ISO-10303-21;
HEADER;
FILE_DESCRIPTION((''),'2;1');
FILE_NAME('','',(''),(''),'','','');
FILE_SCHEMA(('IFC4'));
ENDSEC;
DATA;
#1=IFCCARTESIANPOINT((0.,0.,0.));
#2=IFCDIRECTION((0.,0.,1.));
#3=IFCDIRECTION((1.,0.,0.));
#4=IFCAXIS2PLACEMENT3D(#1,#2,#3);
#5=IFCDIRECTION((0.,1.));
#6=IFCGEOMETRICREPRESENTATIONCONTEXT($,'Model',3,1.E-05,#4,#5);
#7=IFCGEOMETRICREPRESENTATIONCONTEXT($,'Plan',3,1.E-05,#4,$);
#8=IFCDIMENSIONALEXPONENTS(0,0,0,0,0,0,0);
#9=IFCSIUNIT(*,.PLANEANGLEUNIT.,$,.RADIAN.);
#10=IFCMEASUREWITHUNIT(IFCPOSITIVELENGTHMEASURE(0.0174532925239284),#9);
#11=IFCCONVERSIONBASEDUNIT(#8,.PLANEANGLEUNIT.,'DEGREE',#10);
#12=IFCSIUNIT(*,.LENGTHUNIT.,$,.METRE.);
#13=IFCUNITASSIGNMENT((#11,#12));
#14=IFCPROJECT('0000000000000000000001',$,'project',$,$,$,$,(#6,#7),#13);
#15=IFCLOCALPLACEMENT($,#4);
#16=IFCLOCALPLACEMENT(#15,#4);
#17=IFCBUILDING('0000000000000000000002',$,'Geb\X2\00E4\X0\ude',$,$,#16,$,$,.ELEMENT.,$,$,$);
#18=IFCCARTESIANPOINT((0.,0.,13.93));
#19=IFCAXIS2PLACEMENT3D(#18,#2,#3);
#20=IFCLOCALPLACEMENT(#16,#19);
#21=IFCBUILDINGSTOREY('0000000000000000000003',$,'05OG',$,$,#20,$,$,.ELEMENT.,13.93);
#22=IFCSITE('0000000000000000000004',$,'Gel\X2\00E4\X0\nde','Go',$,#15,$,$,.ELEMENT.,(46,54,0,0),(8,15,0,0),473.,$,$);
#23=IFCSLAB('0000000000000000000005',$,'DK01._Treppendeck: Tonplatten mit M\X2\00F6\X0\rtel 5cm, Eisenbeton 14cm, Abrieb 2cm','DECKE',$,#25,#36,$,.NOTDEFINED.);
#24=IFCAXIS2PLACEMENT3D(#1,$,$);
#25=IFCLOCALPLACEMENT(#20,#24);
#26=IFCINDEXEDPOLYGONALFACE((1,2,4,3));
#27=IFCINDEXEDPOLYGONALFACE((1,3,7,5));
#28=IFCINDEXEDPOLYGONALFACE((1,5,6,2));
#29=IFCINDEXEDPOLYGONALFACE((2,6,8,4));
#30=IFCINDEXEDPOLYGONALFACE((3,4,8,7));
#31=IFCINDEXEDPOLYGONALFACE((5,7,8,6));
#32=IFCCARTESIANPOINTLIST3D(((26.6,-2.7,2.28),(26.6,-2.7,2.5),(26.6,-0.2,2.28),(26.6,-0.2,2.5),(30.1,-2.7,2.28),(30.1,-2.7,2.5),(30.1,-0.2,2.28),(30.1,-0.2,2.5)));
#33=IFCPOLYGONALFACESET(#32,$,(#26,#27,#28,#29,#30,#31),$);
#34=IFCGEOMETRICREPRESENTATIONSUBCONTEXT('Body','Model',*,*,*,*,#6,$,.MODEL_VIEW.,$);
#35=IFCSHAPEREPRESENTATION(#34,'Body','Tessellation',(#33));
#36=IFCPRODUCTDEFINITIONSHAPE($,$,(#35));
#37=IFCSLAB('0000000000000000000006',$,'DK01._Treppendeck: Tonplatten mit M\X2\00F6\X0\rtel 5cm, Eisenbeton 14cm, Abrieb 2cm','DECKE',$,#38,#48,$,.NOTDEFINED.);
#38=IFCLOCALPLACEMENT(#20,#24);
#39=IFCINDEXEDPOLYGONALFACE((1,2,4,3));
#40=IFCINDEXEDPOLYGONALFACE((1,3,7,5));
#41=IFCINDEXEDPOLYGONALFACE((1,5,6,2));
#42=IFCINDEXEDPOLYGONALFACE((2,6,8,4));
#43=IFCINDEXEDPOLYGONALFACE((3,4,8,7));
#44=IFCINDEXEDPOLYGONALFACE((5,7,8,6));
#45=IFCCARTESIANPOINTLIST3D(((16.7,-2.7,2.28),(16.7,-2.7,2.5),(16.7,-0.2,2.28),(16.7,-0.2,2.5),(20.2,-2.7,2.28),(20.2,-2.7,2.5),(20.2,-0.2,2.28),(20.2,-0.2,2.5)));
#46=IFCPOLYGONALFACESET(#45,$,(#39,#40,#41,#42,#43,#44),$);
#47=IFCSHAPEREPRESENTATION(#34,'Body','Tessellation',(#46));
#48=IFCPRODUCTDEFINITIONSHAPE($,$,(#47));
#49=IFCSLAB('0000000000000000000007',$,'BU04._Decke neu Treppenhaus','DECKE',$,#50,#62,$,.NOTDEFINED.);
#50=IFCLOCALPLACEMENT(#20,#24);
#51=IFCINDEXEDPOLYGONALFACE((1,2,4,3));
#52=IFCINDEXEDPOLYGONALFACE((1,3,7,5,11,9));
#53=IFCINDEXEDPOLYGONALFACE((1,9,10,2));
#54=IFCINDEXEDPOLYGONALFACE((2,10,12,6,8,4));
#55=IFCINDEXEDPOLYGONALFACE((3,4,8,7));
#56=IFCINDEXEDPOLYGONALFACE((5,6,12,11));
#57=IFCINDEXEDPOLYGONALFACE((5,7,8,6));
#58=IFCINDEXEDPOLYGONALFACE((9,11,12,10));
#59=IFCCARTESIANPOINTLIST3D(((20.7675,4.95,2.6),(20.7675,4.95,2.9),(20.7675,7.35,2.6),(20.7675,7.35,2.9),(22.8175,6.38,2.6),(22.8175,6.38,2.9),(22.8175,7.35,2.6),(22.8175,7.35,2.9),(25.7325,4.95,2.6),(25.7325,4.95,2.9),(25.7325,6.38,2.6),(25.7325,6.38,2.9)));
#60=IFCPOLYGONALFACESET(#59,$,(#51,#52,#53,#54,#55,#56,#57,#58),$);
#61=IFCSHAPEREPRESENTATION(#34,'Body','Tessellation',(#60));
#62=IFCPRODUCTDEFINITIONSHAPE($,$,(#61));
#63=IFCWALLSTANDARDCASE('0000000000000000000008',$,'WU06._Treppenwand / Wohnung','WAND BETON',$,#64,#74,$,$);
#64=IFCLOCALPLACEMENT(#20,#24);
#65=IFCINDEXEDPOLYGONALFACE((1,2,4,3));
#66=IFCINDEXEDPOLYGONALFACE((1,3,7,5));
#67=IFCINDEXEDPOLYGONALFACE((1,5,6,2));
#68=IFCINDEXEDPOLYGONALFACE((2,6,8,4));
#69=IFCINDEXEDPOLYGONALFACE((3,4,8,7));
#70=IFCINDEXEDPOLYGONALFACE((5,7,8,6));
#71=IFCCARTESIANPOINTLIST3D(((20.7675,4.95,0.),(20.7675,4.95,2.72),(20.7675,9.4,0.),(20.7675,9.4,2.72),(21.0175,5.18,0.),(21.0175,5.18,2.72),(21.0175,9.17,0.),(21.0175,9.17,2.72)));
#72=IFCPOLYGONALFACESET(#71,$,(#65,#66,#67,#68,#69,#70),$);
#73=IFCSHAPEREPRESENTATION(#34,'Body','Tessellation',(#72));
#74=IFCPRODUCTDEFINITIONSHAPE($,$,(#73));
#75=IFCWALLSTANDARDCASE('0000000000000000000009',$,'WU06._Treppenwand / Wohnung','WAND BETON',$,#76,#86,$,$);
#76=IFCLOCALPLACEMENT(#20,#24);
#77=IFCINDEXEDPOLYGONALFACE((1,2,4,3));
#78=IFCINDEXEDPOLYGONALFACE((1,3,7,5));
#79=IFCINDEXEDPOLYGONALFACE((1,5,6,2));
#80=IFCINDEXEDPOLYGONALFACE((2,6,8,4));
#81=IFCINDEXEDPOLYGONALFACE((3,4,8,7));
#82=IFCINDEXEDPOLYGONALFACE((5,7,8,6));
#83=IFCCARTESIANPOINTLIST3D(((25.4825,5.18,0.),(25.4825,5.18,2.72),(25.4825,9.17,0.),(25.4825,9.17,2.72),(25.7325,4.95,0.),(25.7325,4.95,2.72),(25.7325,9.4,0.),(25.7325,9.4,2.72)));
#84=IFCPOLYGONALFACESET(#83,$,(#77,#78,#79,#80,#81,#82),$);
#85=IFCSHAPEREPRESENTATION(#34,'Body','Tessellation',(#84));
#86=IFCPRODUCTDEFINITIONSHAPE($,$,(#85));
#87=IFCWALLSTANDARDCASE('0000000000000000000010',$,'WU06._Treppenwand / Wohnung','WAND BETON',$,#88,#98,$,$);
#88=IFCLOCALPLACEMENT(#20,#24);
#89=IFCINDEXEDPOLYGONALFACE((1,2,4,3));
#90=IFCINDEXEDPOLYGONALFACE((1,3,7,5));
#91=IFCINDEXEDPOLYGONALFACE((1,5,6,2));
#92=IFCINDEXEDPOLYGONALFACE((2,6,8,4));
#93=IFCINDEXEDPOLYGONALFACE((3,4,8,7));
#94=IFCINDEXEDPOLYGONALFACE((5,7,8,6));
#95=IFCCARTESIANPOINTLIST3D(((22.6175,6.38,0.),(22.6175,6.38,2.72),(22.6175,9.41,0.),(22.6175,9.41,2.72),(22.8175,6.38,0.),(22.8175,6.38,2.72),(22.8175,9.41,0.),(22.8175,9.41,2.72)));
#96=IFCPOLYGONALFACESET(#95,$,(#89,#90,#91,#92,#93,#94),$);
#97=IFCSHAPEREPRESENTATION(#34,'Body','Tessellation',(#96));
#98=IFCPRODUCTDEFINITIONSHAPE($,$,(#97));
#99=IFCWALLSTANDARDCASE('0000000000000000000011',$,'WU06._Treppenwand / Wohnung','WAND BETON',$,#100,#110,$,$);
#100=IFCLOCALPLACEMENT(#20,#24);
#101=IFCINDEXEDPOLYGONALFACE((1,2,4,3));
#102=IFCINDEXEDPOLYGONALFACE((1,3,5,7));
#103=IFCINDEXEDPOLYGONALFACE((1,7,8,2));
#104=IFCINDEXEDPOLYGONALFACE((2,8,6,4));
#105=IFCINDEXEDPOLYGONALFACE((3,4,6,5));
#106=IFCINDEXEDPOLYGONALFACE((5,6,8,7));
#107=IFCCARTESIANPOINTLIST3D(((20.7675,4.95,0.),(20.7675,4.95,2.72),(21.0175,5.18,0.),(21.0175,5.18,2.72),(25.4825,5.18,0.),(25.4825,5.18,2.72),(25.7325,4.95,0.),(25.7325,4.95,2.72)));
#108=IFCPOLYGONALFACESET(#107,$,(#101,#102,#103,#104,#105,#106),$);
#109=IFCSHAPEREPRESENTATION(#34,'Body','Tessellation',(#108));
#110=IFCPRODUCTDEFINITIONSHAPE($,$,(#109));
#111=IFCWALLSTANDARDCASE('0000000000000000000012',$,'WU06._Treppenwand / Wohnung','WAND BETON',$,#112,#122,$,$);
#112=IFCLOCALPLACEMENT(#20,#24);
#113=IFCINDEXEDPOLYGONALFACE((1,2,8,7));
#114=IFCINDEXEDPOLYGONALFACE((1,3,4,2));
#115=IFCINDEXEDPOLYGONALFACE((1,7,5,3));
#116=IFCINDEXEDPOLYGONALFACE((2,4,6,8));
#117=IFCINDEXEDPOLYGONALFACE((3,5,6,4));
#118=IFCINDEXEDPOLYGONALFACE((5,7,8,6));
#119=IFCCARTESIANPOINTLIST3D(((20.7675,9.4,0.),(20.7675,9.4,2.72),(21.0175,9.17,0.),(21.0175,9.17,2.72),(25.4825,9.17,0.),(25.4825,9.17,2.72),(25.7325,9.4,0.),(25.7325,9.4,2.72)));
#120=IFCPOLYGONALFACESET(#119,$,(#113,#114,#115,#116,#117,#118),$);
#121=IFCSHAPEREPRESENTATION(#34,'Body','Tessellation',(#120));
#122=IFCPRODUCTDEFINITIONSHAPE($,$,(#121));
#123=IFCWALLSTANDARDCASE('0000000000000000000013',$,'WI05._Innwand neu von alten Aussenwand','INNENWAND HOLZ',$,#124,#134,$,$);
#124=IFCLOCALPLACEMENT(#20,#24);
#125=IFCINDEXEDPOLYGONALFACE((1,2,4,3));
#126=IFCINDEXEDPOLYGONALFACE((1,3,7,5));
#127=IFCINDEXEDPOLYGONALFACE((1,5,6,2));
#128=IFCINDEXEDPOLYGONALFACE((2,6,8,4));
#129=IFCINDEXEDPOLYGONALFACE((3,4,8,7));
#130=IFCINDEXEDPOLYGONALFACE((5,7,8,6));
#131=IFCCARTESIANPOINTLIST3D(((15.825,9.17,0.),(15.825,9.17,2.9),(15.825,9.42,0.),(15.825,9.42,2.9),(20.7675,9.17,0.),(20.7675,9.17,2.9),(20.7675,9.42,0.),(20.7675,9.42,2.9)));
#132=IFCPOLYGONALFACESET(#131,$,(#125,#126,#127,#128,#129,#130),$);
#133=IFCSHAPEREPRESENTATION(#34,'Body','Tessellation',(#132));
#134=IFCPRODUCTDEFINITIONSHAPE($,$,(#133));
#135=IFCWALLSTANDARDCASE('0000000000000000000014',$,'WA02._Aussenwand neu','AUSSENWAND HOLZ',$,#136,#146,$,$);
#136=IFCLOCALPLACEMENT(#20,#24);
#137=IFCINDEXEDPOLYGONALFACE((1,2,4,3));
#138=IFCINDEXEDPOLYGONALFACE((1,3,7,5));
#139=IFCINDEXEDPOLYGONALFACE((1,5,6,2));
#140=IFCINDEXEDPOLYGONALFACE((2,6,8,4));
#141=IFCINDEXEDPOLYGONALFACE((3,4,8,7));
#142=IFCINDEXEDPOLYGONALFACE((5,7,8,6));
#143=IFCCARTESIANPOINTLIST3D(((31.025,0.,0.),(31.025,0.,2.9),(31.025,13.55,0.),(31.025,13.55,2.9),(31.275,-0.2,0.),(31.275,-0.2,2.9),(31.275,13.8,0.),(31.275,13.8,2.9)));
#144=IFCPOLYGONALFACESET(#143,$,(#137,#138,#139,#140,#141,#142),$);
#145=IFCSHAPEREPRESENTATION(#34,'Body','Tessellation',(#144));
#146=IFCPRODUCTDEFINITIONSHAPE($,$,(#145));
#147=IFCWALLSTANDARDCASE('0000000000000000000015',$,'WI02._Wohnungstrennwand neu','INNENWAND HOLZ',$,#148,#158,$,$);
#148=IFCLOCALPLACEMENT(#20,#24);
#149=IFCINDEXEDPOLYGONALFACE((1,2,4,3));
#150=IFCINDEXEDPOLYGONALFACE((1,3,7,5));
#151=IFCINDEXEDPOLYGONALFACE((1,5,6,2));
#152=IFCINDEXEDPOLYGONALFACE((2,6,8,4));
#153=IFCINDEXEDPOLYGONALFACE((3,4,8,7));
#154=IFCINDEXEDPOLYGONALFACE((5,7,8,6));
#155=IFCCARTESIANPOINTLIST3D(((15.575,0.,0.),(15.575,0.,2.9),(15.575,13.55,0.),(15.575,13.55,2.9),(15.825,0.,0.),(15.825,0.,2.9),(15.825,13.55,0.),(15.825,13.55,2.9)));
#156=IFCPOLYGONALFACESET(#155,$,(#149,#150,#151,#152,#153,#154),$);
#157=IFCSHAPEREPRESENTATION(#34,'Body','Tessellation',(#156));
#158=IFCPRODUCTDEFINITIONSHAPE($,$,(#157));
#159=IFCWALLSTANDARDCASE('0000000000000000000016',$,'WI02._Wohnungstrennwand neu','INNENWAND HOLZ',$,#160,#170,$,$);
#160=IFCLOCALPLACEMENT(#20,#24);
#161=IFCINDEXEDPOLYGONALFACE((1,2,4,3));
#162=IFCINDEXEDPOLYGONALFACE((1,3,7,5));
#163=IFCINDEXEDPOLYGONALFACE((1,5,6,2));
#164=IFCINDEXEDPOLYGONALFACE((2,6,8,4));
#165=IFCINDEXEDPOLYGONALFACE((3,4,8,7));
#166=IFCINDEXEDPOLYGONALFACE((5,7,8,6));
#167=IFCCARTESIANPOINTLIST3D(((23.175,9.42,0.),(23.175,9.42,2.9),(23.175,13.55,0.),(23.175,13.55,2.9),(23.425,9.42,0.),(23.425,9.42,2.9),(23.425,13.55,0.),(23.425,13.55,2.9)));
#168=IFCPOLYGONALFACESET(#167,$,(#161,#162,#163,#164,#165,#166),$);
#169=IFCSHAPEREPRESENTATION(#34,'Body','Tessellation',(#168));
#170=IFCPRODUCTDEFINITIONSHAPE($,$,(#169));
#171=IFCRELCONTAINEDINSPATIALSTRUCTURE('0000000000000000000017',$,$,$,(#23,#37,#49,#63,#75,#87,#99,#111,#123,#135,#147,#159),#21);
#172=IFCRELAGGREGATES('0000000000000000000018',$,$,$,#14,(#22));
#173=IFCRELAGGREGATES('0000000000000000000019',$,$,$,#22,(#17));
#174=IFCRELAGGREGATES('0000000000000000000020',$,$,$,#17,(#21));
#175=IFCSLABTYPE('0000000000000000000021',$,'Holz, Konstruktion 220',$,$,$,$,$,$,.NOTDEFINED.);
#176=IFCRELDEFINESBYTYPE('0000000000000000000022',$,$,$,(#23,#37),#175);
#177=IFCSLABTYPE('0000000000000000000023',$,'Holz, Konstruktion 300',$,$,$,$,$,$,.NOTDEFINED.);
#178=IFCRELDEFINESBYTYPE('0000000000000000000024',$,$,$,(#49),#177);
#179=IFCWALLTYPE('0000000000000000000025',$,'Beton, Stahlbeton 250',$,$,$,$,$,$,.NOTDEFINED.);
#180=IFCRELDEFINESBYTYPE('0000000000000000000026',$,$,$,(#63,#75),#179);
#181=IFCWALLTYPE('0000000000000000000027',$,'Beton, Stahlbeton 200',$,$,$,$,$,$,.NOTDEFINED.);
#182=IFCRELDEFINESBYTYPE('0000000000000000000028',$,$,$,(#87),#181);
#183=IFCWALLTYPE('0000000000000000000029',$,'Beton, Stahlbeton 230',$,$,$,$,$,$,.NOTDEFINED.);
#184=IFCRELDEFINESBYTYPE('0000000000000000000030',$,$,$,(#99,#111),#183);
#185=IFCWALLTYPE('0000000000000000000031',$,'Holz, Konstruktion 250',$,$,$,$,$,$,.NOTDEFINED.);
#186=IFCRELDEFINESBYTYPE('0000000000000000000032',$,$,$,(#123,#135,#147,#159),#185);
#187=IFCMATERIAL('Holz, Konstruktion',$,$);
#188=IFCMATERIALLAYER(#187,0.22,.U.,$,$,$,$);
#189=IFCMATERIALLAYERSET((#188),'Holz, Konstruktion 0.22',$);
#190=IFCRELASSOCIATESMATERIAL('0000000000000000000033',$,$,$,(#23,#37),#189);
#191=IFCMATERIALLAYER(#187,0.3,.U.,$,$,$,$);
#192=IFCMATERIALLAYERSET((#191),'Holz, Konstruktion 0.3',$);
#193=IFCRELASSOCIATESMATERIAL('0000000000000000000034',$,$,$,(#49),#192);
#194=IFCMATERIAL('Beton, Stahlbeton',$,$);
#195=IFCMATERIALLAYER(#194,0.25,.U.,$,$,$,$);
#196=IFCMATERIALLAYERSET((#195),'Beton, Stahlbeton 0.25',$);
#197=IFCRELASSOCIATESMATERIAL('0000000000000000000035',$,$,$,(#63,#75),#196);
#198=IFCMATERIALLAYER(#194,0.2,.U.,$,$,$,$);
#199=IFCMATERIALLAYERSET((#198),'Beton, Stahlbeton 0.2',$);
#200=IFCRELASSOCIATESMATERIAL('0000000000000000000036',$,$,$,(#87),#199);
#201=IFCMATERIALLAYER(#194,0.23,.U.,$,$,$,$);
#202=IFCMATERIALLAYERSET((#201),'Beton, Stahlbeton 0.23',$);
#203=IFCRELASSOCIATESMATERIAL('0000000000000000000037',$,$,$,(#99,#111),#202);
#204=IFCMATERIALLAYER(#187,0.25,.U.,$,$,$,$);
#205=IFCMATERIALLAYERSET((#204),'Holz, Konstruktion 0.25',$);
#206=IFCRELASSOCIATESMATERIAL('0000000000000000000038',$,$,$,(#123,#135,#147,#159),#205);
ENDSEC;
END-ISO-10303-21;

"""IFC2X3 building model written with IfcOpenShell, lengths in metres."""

from ifc_helpers import new_model, entity, si_unit, converted_unit, direction, frame, origin_with_axes, place, context, subcontext, project, spatial, polyline, outline, extrude, material, layer, layer_set, layer_usage, type_object, element, save


model = new_model("IFC2X3")

# Units and contexts
model_context = context("Model", 3, precision=1e-05, world=origin_with_axes(), true_north=direction((0.0, 1.0)))
plan_context = context("Plan", 3, precision=1e-05, world=origin_with_axes())
body_context = subcontext(model_context, "Body", "Model", "MODEL_VIEW")
ifc_project = project(units=[converted_unit("PLANEANGLEUNIT", "DEGREE", entity("IfcPositiveLengthMeasure", 0.0174532925239284), si_unit("PLANEANGLEUNIT", "RADIAN"), dimensions=[0, 0, 0, 0, 0, 0, 0]), si_unit("LENGTHUNIT", "METRE")], contexts=[model_context, plan_context])

# Site, building, storey
site_placement = place(None, origin_with_axes())
site = spatial("IfcSite", under=ifc_project, at=site_placement, Name="Gelände", Description="Go", CompositionType="ELEMENT", RefLatitude=(46, 54, 0, 0), RefLongitude=(8, 15, 0, 0), RefElevation=473.0)
building_placement = place(site_placement, origin_with_axes())
building = spatial("IfcBuilding", under=site, at=building_placement, Name="Gebäude", CompositionType="ELEMENT")
storey_placement = place(building_placement, frame((0.0, 0.0, 13.93), z_axis=(0.0, 0.0, 1.0), x_axis=(1.0, 0.0, 0.0)))
storey = spatial("IfcBuildingStorey", under=building, at=storey_placement, Name="05OG", CompositionType="ELEMENT", Elevation=13.93)

# Slabs
ifc_material_1 = material(Name="Holz, Konstruktion")
ifc_layer_1 = layer(ifc_material_1, 0.22, ventilated="UNKNOWN")
ifc_layer_set_1 = layer_set([ifc_layer_1], Name="Holz, Konstruktion 0.22")
ifc_layer_usage_1 = layer_usage(ifc_layer_set_1, "AXIS3", "NEGATIVE", 0.22)
slab_type_1 = type_object("IfcSlabType", Name="Holz, Konstruktion 220", PredefinedType="NOTDEFINED")
slab_1_placement = place(storey_placement, frame((26.6, -2.7, 2.5), z_axis=(0.0, 0.0, 1.0), x_axis=(1.0, 0.0, 0.0)))
element("IfcSlab", 1, at=slab_1_placement, inside=storey, type_object=slab_type_1, material=ifc_layer_usage_1, Name="DK01._Treppendeck: Tonplatten mit Mörtel 5cm, Eisenbeton 14cm, Abrieb 2cm", Description="DECKE", PredefinedType="NOTDEFINED", context=body_context, shape_type="SweptSolid", body=[
    extrude(outline(polyline([(0.0, 0.0), (3.5, 0.0), (3.5, 2.5), (0.0, 2.5), (0.0, 0.0)])), frame((0.0, 0.0, -0.22), z_axis=(0.0, 0.0, 1.0), x_axis=(1.0, 0.0, 0.0)), (0.0, 0.0, 1.0), 0.22),
])
ifc_layer_usage_2 = layer_usage(ifc_layer_set_1, "AXIS3", "NEGATIVE", 0.22)
slab_2_placement = place(storey_placement, frame((16.7, -2.7, 2.5), z_axis=(0.0, 0.0, 1.0), x_axis=(1.0, 0.0, 0.0)))
element("IfcSlab", 2, at=slab_2_placement, inside=storey, type_object=slab_type_1, material=ifc_layer_usage_2, Name="DK01._Treppendeck: Tonplatten mit Mörtel 5cm, Eisenbeton 14cm, Abrieb 2cm", Description="DECKE", PredefinedType="NOTDEFINED", context=body_context, shape_type="SweptSolid", body=[
    extrude(outline(polyline([(0.0, 0.0), (3.5, 0.0), (3.5, 2.5), (0.0, 2.5), (0.0, 0.0)])), frame((0.0, 0.0, -0.22), z_axis=(0.0, 0.0, 1.0), x_axis=(1.0, 0.0, 0.0)), (0.0, 0.0, 1.0), 0.22),
])
ifc_layer_2 = layer(ifc_material_1, 0.3, ventilated="UNKNOWN")
ifc_layer_set_2 = layer_set([ifc_layer_2], Name="Holz, Konstruktion 0.3")
ifc_layer_usage_3 = layer_usage(ifc_layer_set_2, "AXIS3", "NEGATIVE", 0.3)
slab_type_2 = type_object("IfcSlabType", Name="Holz, Konstruktion 300", PredefinedType="NOTDEFINED")
slab_3_placement = place(storey_placement, frame((20.7675, 7.35, 2.9), z_axis=(0.0, 0.0, 1.0), x_axis=(1.0, 0.0, 0.0)))
element("IfcSlab", 3, at=slab_3_placement, inside=storey, type_object=slab_type_2, material=ifc_layer_usage_3, Name="BU04._Decke neu Treppenhaus", Description="DECKE", PredefinedType="NOTDEFINED", context=body_context, shape_type="SweptSolid", body=[
    extrude(outline(polyline([(0.0, 0.0), (0.0, -2.4), (4.965, -2.4), (4.965, -0.97), (2.05, -0.97), (2.05, 0.0), (0.0, 0.0)])), frame((0.0, 0.0, -0.3), z_axis=(0.0, 0.0, 1.0), x_axis=(1.0, 0.0, 0.0)), (0.0, 0.0, 1.0), 0.3),
])

# Walls
ifc_material_2 = material(Name="Beton, Stahlbeton")
ifc_layer_3 = layer(ifc_material_2, 0.25, ventilated="UNKNOWN")
ifc_layer_set_3 = layer_set([ifc_layer_3], Name="Beton, Stahlbeton 0.25")
ifc_layer_usage_4 = layer_usage(ifc_layer_set_3, "AXIS2", "NEGATIVE", 0.25)
wall_type_1 = type_object("IfcWallType", Name="Beton, Stahlbeton 250", PredefinedType="NOTDEFINED")
wall_1_placement = place(storey_placement, frame((21.0175, 5.18, 0.0), z_axis=(0.0, 0.0, 1.0), x_axis=(0.0, 1.0, 0.0)))
element("IfcWallStandardCase", 4, at=wall_1_placement, inside=storey, type_object=wall_type_1, material=ifc_layer_usage_4, Name="WU06._Treppenwand / Wohnung", Description="WAND BETON", context=body_context, shape_type="SweptSolid", body=[
    extrude(outline(polyline([(0.0, 0.0), (3.99, 0.0), (4.22, 0.25), (-0.23, 0.25), (0.0, 0.0)])), origin_with_axes(), (0.0, 0.0, 1.0), 2.72),
])
ifc_layer_usage_5 = layer_usage(ifc_layer_set_3, "AXIS2", "NEGATIVE", 0.25)
wall_2_placement = place(storey_placement, frame((25.4825, 9.17, 0.0), z_axis=(0.0, 0.0, 1.0), x_axis=(0.0, -1.0, 0.0)))
element("IfcWallStandardCase", 5, at=wall_2_placement, inside=storey, type_object=wall_type_1, material=ifc_layer_usage_5, Name="WU06._Treppenwand / Wohnung", Description="WAND BETON", context=body_context, shape_type="SweptSolid", body=[
    extrude(outline(polyline([(0.0, 0.0), (3.99, 0.0), (4.22, 0.25), (-0.23, 0.25), (0.0, 0.0)])), origin_with_axes(), (0.0, 0.0, 1.0), 2.72),
])
ifc_layer_4 = layer(ifc_material_2, 0.2, ventilated="UNKNOWN")
ifc_layer_set_4 = layer_set([ifc_layer_4], Name="Beton, Stahlbeton 0.2")
ifc_layer_usage_6 = layer_usage(ifc_layer_set_4, "AXIS2", "POSITIVE", -0.2)
wall_type_2 = type_object("IfcWallType", Name="Beton, Stahlbeton 200", PredefinedType="NOTDEFINED")
wall_3_placement = place(storey_placement, frame((22.6175, 6.38, 0.0), z_axis=(0.0, 0.0, 1.0), x_axis=(0.0, 1.0, 0.0)))
element("IfcWallStandardCase", 6, at=wall_3_placement, inside=storey, type_object=wall_type_2, material=ifc_layer_usage_6, Name="WU06._Treppenwand / Wohnung", Description="WAND BETON", context=body_context, shape_type="SweptSolid", body=[
    extrude(outline(polyline([(0.0, -0.2), (3.03, -0.2), (3.03, 0.0), (0.0, 0.0), (0.0, -0.2)])), origin_with_axes(), (0.0, 0.0, 1.0), 2.72),
])
ifc_layer_5 = layer(ifc_material_2, 0.23, ventilated="UNKNOWN")
ifc_layer_set_5 = layer_set([ifc_layer_5], Name="Beton, Stahlbeton 0.23")
ifc_layer_usage_7 = layer_usage(ifc_layer_set_5, "AXIS2", "NEGATIVE", 0.23)
wall_type_3 = type_object("IfcWallType", Name="Beton, Stahlbeton 230", PredefinedType="NOTDEFINED")
wall_4_placement = place(storey_placement, frame((25.4825, 5.18, 0.0), z_axis=(0.0, 0.0, 1.0), x_axis=(-1.0, 0.0, 0.0)))
element("IfcWallStandardCase", 7, at=wall_4_placement, inside=storey, type_object=wall_type_3, material=ifc_layer_usage_7, Name="WU06._Treppenwand / Wohnung", Description="WAND BETON", context=body_context, shape_type="SweptSolid", body=[
    extrude(outline(polyline([(0.0, 0.0), (4.465, 0.0), (4.715, 0.23), (-0.25, 0.23), (0.0, 0.0)])), origin_with_axes(), (0.0, 0.0, 1.0), 2.72),
])
ifc_layer_usage_8 = layer_usage(ifc_layer_set_5, "AXIS2", "NEGATIVE", 0.23)
wall_5_placement = place(storey_placement, frame((21.0175, 9.17, 0.0), z_axis=(0.0, 0.0, 1.0), x_axis=(1.0, 0.0, 0.0)))
element("IfcWallStandardCase", 8, at=wall_5_placement, inside=storey, type_object=wall_type_3, material=ifc_layer_usage_8, Name="WU06._Treppenwand / Wohnung", Description="WAND BETON", context=body_context, shape_type="SweptSolid", body=[
    extrude(outline(polyline([(0.0, 0.0), (4.465, 0.0), (4.715, 0.23), (-0.25, 0.23), (0.0, 0.0)])), origin_with_axes(), (0.0, 0.0, 1.0), 2.72),
])
ifc_layer_6 = layer(ifc_material_1, 0.25, ventilated="UNKNOWN")
ifc_layer_set_6 = layer_set([ifc_layer_6], Name="Holz, Konstruktion 0.25")
ifc_layer_usage_9 = layer_usage(ifc_layer_set_6, "AXIS2", "NEGATIVE", 0.0)
wall_type_4 = type_object("IfcWallType", Name="Holz, Konstruktion 250", PredefinedType="NOTDEFINED")
wall_6_placement = place(storey_placement, frame((15.825, 9.42, 0.0), z_axis=(0.0, 0.0, 1.0), x_axis=(1.0, 0.0, 0.0)))
element("IfcWallStandardCase", 9, at=wall_6_placement, inside=storey, type_object=wall_type_4, material=ifc_layer_usage_9, Name="WI05._Innwand neu von alten Aussenwand", Description="INNENWAND HOLZ", context=body_context, shape_type="SweptSolid", body=[
    extrude(outline(polyline([(0.0, -0.25), (4.9425, -0.25), (4.9425, 0.0), (0.0, 0.0), (0.0, -0.25)])), origin_with_axes(), (0.0, 0.0, 1.0), 2.9),
])
ifc_layer_usage_10 = layer_usage(ifc_layer_set_6, "AXIS2", "POSITIVE", 0.0)
wall_7_placement = place(storey_placement, frame((31.275, -0.2, 0.0), z_axis=(0.0, 0.0, 1.0), x_axis=(0.0, 1.0, 0.0)))
element("IfcWallStandardCase", 10, at=wall_7_placement, inside=storey, type_object=wall_type_4, material=ifc_layer_usage_10, Name="WA02._Aussenwand neu", Description="AUSSENWAND HOLZ", context=body_context, shape_type="SweptSolid", body=[
    extrude(outline(polyline([(0.0, 0.0), (14.0, 0.0), (13.75, 0.25), (0.2, 0.25), (0.0, 0.0)])), origin_with_axes(), (0.0, 0.0, 1.0), 2.9),
])
ifc_layer_usage_11 = layer_usage(ifc_layer_set_6, "AXIS2", "NEGATIVE", 0.0)
wall_8_placement = place(storey_placement, frame((15.825, 13.55, 0.0), z_axis=(0.0, 0.0, 1.0), x_axis=(0.0, -1.0, 0.0)))
element("IfcWallStandardCase", 11, at=wall_8_placement, inside=storey, type_object=wall_type_4, material=ifc_layer_usage_11, Name="WI02._Wohnungstrennwand neu", Description="INNENWAND HOLZ", context=body_context, shape_type="SweptSolid", body=[
    extrude(outline(polyline([(0.0, -0.25), (13.55, -0.25), (13.55, 0.0), (0.0, 0.0), (0.0, -0.25)])), origin_with_axes(), (0.0, 0.0, 1.0), 2.9),
])
ifc_layer_usage_12 = layer_usage(ifc_layer_set_6, "AXIS2", "NEGATIVE", 0.0)
wall_9_placement = place(storey_placement, frame((23.425, 13.55, 0.0), z_axis=(0.0, 0.0, 1.0), x_axis=(0.0, -1.0, 0.0)))
element("IfcWallStandardCase", 12, at=wall_9_placement, inside=storey, type_object=wall_type_4, material=ifc_layer_usage_12, Name="WI02._Wohnungstrennwand neu", Description="INNENWAND HOLZ", context=body_context, shape_type="SweptSolid", body=[
    extrude(outline(polyline([(0.0, -0.25), (4.13, -0.25), (4.13, 0.0), (0.0, 0.0), (0.0, -0.25)])), origin_with_axes(), (0.0, 0.0, 1.0), 2.9),
])

save(model, "model.ifc")
